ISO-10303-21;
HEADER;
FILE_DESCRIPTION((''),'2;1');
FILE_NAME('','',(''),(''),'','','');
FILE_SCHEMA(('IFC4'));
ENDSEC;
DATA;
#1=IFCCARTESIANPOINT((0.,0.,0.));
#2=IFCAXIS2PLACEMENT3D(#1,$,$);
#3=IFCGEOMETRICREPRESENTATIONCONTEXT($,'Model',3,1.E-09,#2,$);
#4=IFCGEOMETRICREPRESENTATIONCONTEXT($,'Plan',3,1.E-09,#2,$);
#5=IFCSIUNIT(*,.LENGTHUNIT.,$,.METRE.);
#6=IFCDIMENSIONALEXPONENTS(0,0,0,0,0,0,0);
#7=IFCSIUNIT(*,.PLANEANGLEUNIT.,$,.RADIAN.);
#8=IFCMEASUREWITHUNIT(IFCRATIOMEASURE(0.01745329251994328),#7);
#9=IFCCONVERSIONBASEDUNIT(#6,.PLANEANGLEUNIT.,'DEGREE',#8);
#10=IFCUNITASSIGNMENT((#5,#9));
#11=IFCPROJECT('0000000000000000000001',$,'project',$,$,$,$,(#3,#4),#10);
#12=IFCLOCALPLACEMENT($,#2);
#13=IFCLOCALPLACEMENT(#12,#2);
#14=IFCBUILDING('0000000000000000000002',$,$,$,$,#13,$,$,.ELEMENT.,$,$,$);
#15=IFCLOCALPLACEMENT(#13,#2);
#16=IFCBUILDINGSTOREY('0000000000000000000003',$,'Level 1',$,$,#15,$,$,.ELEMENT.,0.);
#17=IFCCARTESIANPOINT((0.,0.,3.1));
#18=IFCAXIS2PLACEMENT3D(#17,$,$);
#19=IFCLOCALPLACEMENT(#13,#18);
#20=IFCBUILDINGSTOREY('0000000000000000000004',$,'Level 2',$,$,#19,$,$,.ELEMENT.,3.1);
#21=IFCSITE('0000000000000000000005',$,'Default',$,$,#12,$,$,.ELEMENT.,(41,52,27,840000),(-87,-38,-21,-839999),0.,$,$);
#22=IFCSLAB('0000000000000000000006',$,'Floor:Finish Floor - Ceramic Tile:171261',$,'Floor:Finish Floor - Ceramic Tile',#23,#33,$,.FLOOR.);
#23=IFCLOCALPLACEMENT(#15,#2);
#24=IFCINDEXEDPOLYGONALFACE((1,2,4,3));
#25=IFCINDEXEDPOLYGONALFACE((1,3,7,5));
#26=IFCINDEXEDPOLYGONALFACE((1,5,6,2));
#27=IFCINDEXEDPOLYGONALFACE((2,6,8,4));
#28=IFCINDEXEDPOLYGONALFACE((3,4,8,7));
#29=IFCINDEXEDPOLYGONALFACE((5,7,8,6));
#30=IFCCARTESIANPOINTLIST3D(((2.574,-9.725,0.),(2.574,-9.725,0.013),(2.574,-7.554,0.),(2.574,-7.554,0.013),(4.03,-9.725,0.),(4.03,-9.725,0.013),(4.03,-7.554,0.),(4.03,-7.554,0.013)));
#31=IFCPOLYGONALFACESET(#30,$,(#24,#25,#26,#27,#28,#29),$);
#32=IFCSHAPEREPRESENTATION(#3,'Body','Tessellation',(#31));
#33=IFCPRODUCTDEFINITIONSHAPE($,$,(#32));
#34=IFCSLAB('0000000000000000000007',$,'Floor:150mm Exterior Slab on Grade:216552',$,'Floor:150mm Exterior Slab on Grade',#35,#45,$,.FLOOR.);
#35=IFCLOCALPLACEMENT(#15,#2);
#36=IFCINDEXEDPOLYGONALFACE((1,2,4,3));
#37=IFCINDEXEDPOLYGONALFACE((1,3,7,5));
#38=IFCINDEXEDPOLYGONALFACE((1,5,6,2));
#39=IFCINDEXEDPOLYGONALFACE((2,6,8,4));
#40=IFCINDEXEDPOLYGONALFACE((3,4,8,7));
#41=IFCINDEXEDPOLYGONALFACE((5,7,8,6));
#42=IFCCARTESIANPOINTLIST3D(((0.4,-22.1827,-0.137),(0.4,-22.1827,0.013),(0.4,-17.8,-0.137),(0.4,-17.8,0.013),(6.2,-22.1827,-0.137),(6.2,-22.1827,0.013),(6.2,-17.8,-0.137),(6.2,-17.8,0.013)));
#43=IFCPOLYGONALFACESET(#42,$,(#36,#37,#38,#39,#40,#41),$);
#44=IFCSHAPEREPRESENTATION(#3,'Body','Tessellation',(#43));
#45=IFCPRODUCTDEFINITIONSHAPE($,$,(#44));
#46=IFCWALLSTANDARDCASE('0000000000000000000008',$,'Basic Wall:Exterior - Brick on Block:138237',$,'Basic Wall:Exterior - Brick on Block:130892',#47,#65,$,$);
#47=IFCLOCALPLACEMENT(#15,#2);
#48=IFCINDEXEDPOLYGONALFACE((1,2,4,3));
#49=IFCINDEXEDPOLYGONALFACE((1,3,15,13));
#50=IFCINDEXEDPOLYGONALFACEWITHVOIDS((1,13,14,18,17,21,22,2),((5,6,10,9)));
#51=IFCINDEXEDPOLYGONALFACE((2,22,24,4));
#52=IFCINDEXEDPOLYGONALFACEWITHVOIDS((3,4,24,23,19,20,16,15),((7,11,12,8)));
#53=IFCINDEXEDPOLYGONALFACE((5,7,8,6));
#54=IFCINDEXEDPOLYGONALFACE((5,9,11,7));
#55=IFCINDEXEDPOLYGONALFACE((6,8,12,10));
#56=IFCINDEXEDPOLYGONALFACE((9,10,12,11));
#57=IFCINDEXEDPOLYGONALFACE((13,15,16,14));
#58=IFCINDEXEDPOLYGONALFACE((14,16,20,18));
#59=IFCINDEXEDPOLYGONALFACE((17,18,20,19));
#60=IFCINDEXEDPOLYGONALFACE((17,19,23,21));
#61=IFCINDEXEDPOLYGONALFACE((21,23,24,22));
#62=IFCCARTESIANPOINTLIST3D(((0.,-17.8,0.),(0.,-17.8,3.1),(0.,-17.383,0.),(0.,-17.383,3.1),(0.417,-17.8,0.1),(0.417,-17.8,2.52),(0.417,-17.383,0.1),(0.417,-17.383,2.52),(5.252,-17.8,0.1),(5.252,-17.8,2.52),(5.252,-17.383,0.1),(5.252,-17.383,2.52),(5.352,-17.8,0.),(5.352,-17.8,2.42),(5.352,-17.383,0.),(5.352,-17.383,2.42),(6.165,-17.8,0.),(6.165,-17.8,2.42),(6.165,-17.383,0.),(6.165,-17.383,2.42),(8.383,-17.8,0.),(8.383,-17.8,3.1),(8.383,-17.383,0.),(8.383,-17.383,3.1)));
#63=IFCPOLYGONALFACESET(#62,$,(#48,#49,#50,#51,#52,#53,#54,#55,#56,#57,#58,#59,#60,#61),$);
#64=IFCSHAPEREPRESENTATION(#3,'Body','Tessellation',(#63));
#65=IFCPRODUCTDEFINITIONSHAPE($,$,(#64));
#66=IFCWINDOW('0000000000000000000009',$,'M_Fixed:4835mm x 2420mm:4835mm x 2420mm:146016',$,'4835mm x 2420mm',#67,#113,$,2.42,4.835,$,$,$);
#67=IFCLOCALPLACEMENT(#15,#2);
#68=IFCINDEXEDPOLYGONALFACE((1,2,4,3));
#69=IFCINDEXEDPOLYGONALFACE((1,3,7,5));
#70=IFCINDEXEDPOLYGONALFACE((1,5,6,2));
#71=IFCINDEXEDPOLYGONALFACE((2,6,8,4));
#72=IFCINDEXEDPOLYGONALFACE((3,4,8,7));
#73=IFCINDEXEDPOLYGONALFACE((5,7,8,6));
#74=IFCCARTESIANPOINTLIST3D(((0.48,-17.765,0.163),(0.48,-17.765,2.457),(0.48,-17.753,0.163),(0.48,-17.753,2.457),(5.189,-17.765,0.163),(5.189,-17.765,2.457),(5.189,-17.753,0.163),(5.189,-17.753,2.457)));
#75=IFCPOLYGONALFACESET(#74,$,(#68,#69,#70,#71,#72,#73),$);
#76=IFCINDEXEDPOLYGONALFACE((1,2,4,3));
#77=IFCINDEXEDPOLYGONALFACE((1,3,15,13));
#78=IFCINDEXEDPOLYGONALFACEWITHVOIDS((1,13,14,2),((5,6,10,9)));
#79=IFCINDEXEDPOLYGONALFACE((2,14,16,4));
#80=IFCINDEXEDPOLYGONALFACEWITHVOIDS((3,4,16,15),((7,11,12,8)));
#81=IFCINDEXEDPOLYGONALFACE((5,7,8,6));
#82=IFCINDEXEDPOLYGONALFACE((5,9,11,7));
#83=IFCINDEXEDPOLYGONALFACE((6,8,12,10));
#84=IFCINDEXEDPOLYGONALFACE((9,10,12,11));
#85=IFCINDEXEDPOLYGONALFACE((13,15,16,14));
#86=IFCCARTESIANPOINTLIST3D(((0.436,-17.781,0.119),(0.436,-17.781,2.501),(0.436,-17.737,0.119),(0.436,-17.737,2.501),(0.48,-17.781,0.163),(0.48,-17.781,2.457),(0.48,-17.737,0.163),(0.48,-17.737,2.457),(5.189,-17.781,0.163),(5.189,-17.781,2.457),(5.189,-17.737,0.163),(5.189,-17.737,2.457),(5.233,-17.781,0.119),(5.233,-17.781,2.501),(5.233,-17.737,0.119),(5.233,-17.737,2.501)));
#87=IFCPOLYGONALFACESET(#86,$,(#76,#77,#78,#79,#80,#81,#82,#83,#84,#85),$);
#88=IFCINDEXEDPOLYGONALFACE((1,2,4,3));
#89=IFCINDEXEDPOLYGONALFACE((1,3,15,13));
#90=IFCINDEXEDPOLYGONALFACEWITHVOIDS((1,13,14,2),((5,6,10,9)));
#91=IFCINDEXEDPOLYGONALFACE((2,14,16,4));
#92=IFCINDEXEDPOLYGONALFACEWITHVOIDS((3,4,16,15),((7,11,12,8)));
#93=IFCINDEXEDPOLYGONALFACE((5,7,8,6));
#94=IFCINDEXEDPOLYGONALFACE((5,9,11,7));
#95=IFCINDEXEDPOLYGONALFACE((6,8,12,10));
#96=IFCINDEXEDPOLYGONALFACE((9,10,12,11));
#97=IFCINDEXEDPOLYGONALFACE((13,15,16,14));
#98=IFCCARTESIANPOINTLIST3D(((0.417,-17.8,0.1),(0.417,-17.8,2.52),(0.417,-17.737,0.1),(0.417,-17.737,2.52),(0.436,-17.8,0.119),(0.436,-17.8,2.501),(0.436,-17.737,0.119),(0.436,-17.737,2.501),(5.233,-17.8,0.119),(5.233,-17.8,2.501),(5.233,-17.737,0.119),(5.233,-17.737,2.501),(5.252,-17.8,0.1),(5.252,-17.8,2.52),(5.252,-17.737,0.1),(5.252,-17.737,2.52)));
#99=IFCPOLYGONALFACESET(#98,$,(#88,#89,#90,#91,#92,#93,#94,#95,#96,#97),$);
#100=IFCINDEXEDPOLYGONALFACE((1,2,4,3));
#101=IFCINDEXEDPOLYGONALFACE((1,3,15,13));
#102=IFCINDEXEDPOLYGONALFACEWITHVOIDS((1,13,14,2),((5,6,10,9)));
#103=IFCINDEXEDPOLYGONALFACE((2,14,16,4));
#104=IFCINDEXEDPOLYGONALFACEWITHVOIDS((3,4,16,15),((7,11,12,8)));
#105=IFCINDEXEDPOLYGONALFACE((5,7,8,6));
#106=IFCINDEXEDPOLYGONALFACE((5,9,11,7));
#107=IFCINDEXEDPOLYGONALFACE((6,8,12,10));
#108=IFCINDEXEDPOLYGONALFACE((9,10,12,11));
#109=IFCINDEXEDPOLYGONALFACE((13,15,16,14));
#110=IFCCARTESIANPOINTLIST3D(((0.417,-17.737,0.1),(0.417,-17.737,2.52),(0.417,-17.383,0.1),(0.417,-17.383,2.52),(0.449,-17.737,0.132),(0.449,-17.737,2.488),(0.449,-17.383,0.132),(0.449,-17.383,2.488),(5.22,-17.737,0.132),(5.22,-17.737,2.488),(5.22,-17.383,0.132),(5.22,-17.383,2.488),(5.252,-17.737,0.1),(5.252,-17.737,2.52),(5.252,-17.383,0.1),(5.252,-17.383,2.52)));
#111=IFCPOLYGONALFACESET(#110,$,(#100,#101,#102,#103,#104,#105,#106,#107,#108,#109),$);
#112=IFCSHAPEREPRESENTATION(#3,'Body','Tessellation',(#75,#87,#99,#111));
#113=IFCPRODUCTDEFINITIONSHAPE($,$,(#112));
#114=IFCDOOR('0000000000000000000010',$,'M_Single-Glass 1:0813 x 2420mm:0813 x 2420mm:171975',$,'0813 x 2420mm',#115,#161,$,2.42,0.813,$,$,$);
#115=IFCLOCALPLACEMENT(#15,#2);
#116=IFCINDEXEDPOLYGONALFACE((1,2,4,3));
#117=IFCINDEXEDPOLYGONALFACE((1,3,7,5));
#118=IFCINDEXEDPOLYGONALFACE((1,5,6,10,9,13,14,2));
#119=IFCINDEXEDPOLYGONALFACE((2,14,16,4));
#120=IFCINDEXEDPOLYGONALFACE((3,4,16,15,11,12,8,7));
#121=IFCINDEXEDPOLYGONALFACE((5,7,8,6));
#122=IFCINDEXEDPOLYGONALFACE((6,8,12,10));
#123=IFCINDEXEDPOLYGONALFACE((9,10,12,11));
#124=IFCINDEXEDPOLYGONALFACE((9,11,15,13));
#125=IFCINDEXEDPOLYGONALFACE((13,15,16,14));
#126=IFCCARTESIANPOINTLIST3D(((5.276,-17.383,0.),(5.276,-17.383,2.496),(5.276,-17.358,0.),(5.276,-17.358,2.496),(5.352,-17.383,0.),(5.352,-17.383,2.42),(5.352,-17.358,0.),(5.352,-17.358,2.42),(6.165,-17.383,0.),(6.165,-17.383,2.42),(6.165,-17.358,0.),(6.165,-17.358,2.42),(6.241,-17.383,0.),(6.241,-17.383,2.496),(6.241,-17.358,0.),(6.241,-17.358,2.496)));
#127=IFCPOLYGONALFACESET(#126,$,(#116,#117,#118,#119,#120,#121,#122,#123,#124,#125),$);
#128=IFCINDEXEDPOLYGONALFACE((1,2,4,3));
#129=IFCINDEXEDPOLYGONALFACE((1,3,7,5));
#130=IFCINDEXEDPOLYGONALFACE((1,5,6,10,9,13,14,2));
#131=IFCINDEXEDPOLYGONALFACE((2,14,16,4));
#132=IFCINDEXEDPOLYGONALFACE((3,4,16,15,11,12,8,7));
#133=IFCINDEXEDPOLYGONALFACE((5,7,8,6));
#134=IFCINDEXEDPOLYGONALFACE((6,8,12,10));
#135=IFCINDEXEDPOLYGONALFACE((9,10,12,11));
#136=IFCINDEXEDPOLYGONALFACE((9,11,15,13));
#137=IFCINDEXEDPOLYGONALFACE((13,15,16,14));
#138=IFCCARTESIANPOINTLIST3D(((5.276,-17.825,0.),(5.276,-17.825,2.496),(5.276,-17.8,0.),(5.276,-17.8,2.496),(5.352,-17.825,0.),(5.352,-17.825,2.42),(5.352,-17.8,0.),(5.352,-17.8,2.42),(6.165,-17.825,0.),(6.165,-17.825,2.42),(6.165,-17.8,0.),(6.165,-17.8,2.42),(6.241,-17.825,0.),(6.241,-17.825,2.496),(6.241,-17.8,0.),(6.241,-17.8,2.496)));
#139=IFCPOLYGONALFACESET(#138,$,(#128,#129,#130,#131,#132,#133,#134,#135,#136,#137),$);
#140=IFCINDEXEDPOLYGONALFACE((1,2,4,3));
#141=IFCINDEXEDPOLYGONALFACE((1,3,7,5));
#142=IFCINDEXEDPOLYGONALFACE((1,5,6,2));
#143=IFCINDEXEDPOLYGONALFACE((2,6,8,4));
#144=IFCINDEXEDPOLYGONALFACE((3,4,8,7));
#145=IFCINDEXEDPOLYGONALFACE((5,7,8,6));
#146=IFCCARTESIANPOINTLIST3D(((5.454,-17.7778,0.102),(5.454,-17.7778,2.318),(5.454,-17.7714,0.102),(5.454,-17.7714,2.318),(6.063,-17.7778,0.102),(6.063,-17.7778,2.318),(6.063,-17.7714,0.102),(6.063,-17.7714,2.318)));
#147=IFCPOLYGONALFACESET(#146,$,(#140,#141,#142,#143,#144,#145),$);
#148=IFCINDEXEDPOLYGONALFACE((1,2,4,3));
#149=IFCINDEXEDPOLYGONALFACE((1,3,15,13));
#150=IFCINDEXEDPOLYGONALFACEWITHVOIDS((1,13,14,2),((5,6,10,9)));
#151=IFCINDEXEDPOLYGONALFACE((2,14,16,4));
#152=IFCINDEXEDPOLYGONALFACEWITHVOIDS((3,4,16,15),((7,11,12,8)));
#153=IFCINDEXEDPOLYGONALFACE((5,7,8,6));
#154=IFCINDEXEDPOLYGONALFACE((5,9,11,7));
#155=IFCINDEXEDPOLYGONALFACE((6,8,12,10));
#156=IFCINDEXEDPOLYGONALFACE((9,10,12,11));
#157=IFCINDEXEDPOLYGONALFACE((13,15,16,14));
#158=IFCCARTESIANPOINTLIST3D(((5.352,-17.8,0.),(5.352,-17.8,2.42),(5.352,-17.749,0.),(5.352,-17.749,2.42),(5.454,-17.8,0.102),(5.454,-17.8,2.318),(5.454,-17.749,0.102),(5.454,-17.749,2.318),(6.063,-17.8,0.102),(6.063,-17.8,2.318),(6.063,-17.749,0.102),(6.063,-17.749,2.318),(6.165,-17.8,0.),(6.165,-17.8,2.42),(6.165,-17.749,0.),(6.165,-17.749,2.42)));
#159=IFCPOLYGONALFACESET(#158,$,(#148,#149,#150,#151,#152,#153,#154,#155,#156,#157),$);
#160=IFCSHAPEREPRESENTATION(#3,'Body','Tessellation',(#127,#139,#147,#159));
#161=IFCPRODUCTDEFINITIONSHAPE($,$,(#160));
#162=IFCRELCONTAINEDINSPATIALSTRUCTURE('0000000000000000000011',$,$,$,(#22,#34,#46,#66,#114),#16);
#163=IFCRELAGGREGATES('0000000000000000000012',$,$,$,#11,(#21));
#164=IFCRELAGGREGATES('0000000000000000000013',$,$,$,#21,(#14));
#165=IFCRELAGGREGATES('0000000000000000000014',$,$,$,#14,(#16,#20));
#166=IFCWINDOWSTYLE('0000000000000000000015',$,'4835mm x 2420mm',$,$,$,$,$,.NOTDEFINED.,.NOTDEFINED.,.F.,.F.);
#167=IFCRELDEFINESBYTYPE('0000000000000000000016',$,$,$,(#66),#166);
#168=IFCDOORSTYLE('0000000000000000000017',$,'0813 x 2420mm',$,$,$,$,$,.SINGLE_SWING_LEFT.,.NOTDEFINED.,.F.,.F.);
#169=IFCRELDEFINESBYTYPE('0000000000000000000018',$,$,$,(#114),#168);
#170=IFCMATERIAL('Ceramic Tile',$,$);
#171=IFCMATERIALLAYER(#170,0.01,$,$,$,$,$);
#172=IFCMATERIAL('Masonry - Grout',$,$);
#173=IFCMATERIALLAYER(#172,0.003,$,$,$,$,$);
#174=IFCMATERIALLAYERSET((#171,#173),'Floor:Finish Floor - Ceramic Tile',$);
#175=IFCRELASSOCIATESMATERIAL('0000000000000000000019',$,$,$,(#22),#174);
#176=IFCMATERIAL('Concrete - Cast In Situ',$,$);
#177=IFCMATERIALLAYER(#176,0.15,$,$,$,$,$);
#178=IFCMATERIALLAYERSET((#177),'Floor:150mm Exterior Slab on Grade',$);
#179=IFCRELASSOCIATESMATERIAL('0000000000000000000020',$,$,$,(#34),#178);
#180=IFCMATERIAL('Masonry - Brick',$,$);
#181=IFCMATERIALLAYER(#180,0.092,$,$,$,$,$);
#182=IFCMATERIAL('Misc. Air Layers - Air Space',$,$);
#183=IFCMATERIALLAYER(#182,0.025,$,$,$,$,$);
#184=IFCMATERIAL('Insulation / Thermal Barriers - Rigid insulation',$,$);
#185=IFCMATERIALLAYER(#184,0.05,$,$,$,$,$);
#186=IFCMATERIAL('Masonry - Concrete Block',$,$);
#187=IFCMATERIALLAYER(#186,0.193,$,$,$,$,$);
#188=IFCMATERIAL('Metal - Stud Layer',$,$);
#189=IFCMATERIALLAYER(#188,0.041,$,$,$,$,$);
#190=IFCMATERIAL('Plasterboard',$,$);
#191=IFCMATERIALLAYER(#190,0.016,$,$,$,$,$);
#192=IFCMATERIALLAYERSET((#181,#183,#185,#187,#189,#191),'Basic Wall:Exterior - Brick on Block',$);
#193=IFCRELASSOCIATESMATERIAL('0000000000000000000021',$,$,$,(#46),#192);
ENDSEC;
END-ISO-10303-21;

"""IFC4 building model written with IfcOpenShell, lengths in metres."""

from ifc_helpers import new_model, entity, si_unit, converted_unit, frame, frame_2d, origin, origin_2d_with_axis, place, context, project, spatial, polyline, rectangle, outline, extrude, source, transform, mapped, material, layer, layer_set, layer_usage, type_object, type_shapes, element, fill, save


model = new_model("IFC4")

# Units and contexts
model_context = context("Model", 3, precision=1e-09, world=origin())
plan_context = context("Plan", 3, precision=1e-09, world=origin())
ifc_project = project(units=[si_unit("LENGTHUNIT", "METRE"), converted_unit("PLANEANGLEUNIT", "DEGREE", entity("IfcRatioMeasure", 0.01745329251994328), si_unit("PLANEANGLEUNIT", "RADIAN"), dimensions=[0, 0, 0, 0, 0, 0, 0])], contexts=[model_context, plan_context])

# Site, building, storey
site_placement = place(None, origin())
site = spatial("IfcSite", under=ifc_project, at=site_placement, Name="Default", CompositionType="ELEMENT", RefLatitude=(41, 52, 27, 840000), RefLongitude=(-87, -38, -21, -839999), RefElevation=0.0)
building_placement = place(site_placement, origin())
building = spatial("IfcBuilding", under=site, at=building_placement, CompositionType="ELEMENT")
storey_1_placement = place(building_placement, origin())
storey_1 = spatial("IfcBuildingStorey", under=building, at=storey_1_placement, Name="Level 1", CompositionType="ELEMENT", Elevation=0.0)

# Slabs
ifc_material_1 = material(Name="Ceramic Tile")
ifc_layer_1 = layer(ifc_material_1, 0.01)
ifc_material_2 = material(Name="Masonry - Grout")
ifc_layer_2 = layer(ifc_material_2, 0.003)
ifc_layer_set_1 = layer_set([ifc_layer_1, ifc_layer_2], Name="Floor:Finish Floor - Ceramic Tile")
ifc_layer_usage_1 = layer_usage(ifc_layer_set_1, "AXIS3", "POSITIVE", 0.0)
slab_1_placement = place(storey_1_placement, frame((2.574, -9.725, 0.0)))
element("IfcSlab", 1, at=slab_1_placement, inside=storey_1, material=ifc_layer_usage_1, Name="Floor:Finish Floor - Ceramic Tile:171261", ObjectType="Floor:Finish Floor - Ceramic Tile", PredefinedType="FLOOR", context=model_context, shape_type="SweptSolid", body=[
    extrude(rectangle(XDim=2.171, YDim=1.456, at=frame_2d((0.0, 0.0), x_axis=(0.0, -1.0))), frame((0.728, 1.0855, 0.013), z_axis=(0.0, 0.0, -1.0), x_axis=(-1.0, 0.0, 0.0)), (0.0, 0.0, 1.0), 0.013),
])
ifc_material_3 = material(Name="Concrete - Cast In Situ")
ifc_layer_3 = layer(ifc_material_3, 0.15)
ifc_layer_set_2 = layer_set([ifc_layer_3], Name="Floor:150mm Exterior Slab on Grade")
ifc_layer_usage_2 = layer_usage(ifc_layer_set_2, "AXIS3", "POSITIVE", 0.0)
slab_2_placement = place(storey_1_placement, frame((0.4, -22.1827, -0.137)))
element("IfcSlab", 2, at=slab_2_placement, inside=storey_1, material=ifc_layer_usage_2, Name="Floor:150mm Exterior Slab on Grade:216552", ObjectType="Floor:150mm Exterior Slab on Grade", PredefinedType="FLOOR", context=model_context, shape_type="SweptSolid", body=[
    extrude(rectangle(XDim=5.8, YDim=4.3827, at=origin_2d_with_axis()), frame((2.9, 2.1914, 0.15), z_axis=(0.0, 0.0, -1.0), x_axis=(-1.0, 0.0, 0.0)), (0.0, 0.0, 1.0), 0.15),
])

# Wall, openings, window, door
ifc_material_4 = material(Name="Masonry - Brick")
ifc_layer_4 = layer(ifc_material_4, 0.092)
ifc_material_5 = material(Name="Misc. Air Layers - Air Space")
ifc_layer_5 = layer(ifc_material_5, 0.025)
ifc_material_6 = material(Name="Insulation / Thermal Barriers - Rigid insulation")
ifc_layer_6 = layer(ifc_material_6, 0.05)
ifc_material_7 = material(Name="Masonry - Concrete Block")
ifc_layer_7 = layer(ifc_material_7, 0.193)
ifc_material_8 = material(Name="Metal - Stud Layer")
ifc_layer_8 = layer(ifc_material_8, 0.041)
ifc_material_9 = material(Name="Plasterboard")
ifc_layer_9 = layer(ifc_material_9, 0.016)
ifc_layer_set_3 = layer_set([ifc_layer_4, ifc_layer_5, ifc_layer_6, ifc_layer_7, ifc_layer_8, ifc_layer_9], Name="Basic Wall:Exterior - Brick on Block")
ifc_layer_usage_3 = layer_usage(ifc_layer_set_3, "AXIS2", "NEGATIVE", 0.2085)
wall_1_placement = place(storey_1_placement, frame((8.383, -17.5915, 0.0), z_axis=(0.0, 0.0, 1.0), x_axis=(-1.0, 0.0, 0.0)))
wall_1 = element("IfcWallStandardCase", 3, at=wall_1_placement, inside=storey_1, material=ifc_layer_usage_3, Name="Basic Wall:Exterior - Brick on Block:138237", ObjectType="Basic Wall:Exterior - Brick on Block:130892", context=model_context, shape_type="SweptSolid", body=[
    extrude(rectangle(XDim=8.383, YDim=0.417, at=frame_2d((4.1915, 0.0), x_axis=(-1.0, 0.0))), origin(), (0.0, 0.0, 1.0), 3.1),
])
opening_1_placement = place(wall_1_placement, frame((3.131, -0.2085, 0.1)))
opening_1 = element("IfcOpeningElement", 4, at=opening_1_placement, cuts=wall_1, ObjectType="Opening", context=model_context, shape_type="SweptSolid", body=[
    extrude(rectangle(XDim=2.42, YDim=4.835, at=frame_2d((1.21, 2.4175), x_axis=(1.0, 0.0))), frame((0.0, 0.0, 0.0), z_axis=(0.0, 1.0, 0.0), x_axis=(0.0, 0.0, 1.0)), (0.0, 0.0, 1.0), 0.417),
])
opening_2_placement = place(wall_1_placement, frame((2.218, -0.2085, 0.0)))
opening_2 = element("IfcOpeningElement", 5, at=opening_2_placement, cuts=wall_1, ObjectType="Opening", context=model_context, shape_type="SweptSolid", body=[
    extrude(rectangle(XDim=0.813, YDim=2.42, at=frame_2d((1.21, 0.4065), x_axis=(0.0, -1.0))), frame((0.0, 0.0, 0.0), z_axis=(0.0, 1.0, 0.0), x_axis=(0.0, 0.0, 1.0)), (0.0, 0.0, 1.0), 0.417),
])
window_style_1 = type_object("IfcWindowStyle", Name="4835mm x 2420mm", ConstructionType="NOTDEFINED", OperationType="NOTDEFINED", ParameterTakesPrecedence=False, Sizeable=False)
shared_shape_1 = source(origin(), model_context, "Body", "SweptSolid", [
    extrude(rectangle(XDim=0.012, YDim=4.709, at=origin_2d_with_axis()), frame((2.4175, 0.376, 0.063), z_axis=(0.0, 0.0, 1.0), x_axis=(0.0, -1.0, 0.0)), (0.0, 0.0, 1.0), 2.294),
    extrude(outline(polyline([(-2.3985, -1.191), (2.3985, -1.191), (2.3985, 1.191), (-2.3985, 1.191), (-2.3985, -1.191)]), holes=[polyline([(-2.3545, -1.147), (-2.3545, 1.147), (2.3545, 1.147), (2.3545, -1.147), (-2.3545, -1.147)])]), frame((2.4175, 0.354, 1.21), z_axis=(0.0, 1.0, 0.0), x_axis=(1.0, 0.0, 0.0)), (0.0, 0.0, 1.0), 0.044),
    extrude(outline(polyline([(-2.4175, -1.21), (2.4175, -1.21), (2.4175, 1.21), (-2.4175, 1.21), (-2.4175, -1.21)]), holes=[polyline([(-2.3985, -1.191), (-2.3985, 1.191), (2.3985, 1.191), (2.3985, -1.191), (-2.3985, -1.191)])]), frame((2.4175, 0.354, 1.21), z_axis=(0.0, 1.0, 0.0), x_axis=(1.0, 0.0, 0.0)), (0.0, 0.0, 1.0), 0.063),
    extrude(outline(polyline([(-2.4175, -1.21), (2.4175, -1.21), (2.4175, 1.21), (-2.4175, 1.21), (-2.4175, -1.21)]), holes=[polyline([(-2.3855, -1.178), (-2.3855, 1.178), (2.3855, 1.178), (2.3855, -1.178), (-2.3855, -1.178)])]), frame((2.4175, 0.0, 1.21), z_axis=(0.0, 1.0, 0.0), x_axis=(1.0, 0.0, 0.0)), (0.0, 0.0, 1.0), 0.354),
])
type_shapes(window_style_1, [shared_shape_1])
window_1_placement = place(opening_1_placement, origin())
window_1 = element("IfcWindow", 6, at=window_1_placement, inside=storey_1, type_object=window_style_1, Name="M_Fixed:4835mm x 2420mm:4835mm x 2420mm:146016", ObjectType="4835mm x 2420mm", OverallHeight=2.42, OverallWidth=4.835, context=model_context, shape_type="MappedRepresentation", body=[
    mapped(shared_shape_1, transform((0.0, 0.0, 0.0), scale=1.0)),
])
fill(opening_1, window_1)
door_style_1 = type_object("IfcDoorStyle", Name="0813 x 2420mm", ConstructionType="NOTDEFINED", OperationType="SINGLE_SWING_LEFT", ParameterTakesPrecedence=False, Sizeable=False)
shared_shape_2 = source(origin(), model_context, "Body", "SweptSolid", [
    extrude(outline(polyline([(-0.4065, -1.191), (-0.4065, 1.229), (-0.4825, 1.229), (-0.4825, -1.267), (0.4825, -1.267), (0.4825, 1.229), (0.4065, 1.229), (0.4065, -1.191), (-0.4065, -1.191)])), frame((0.4065, 0.0, 1.229), z_axis=(0.0, 1.0, 0.0), x_axis=(1.0, 0.0, 0.0)), (0.0, 0.0, -1.0), 0.025),
    extrude(outline(polyline([(-0.4065, -1.191), (-0.4065, 1.229), (-0.4825, 1.229), (-0.4825, -1.267), (0.4825, -1.267), (0.4825, 1.229), (0.4065, 1.229), (0.4065, -1.191), (-0.4065, -1.191)])), frame((0.4065, 0.442, 1.229), z_axis=(0.0, 1.0, 0.0), x_axis=(1.0, 0.0, 0.0)), (0.0, 0.0, -1.0), 0.025),
    extrude(rectangle(XDim=0.609, YDim=0.0064, at=origin_2d_with_axis()), frame((0.4065, 0.3916, 0.102)), (0.0, 0.0, 1.0), 2.216),
    extrude(outline(polyline([(-1.21, -0.4065), (1.21, -0.4065), (1.21, 0.4065), (-1.21, 0.4065), (-1.21, -0.4065)]), holes=[polyline([(-1.108, 0.3045), (1.108, 0.3045), (1.108, -0.3045), (-1.108, -0.3045), (-1.108, 0.3045)])]), frame((0.4065, 0.417, 1.21), z_axis=(0.0, -1.0, 0.0), x_axis=(0.0, 0.0, -1.0)), (0.0, 0.0, 1.0), 0.051),
])
type_shapes(door_style_1, [shared_shape_2])
door_1_placement = place(opening_2_placement, origin())
door_1 = element("IfcDoor", 7, at=door_1_placement, inside=storey_1, type_object=door_style_1, Name="M_Single-Glass 1:0813 x 2420mm:0813 x 2420mm:171975", ObjectType="0813 x 2420mm", OverallHeight=2.42, OverallWidth=0.813, context=model_context, shape_type="MappedRepresentation", body=[
    mapped(shared_shape_2, transform((0.0, 0.0, 0.0), scale=1.0)),
])
fill(opening_2, door_1)

# Shared definitions
storey_2_placement = place(building_placement, frame((0.0, 0.0, 3.1)))
storey_2 = spatial("IfcBuildingStorey", under=building, at=storey_2_placement, Name="Level 2", CompositionType="ELEMENT", Elevation=3.1)

save(model, "model.ifc")
